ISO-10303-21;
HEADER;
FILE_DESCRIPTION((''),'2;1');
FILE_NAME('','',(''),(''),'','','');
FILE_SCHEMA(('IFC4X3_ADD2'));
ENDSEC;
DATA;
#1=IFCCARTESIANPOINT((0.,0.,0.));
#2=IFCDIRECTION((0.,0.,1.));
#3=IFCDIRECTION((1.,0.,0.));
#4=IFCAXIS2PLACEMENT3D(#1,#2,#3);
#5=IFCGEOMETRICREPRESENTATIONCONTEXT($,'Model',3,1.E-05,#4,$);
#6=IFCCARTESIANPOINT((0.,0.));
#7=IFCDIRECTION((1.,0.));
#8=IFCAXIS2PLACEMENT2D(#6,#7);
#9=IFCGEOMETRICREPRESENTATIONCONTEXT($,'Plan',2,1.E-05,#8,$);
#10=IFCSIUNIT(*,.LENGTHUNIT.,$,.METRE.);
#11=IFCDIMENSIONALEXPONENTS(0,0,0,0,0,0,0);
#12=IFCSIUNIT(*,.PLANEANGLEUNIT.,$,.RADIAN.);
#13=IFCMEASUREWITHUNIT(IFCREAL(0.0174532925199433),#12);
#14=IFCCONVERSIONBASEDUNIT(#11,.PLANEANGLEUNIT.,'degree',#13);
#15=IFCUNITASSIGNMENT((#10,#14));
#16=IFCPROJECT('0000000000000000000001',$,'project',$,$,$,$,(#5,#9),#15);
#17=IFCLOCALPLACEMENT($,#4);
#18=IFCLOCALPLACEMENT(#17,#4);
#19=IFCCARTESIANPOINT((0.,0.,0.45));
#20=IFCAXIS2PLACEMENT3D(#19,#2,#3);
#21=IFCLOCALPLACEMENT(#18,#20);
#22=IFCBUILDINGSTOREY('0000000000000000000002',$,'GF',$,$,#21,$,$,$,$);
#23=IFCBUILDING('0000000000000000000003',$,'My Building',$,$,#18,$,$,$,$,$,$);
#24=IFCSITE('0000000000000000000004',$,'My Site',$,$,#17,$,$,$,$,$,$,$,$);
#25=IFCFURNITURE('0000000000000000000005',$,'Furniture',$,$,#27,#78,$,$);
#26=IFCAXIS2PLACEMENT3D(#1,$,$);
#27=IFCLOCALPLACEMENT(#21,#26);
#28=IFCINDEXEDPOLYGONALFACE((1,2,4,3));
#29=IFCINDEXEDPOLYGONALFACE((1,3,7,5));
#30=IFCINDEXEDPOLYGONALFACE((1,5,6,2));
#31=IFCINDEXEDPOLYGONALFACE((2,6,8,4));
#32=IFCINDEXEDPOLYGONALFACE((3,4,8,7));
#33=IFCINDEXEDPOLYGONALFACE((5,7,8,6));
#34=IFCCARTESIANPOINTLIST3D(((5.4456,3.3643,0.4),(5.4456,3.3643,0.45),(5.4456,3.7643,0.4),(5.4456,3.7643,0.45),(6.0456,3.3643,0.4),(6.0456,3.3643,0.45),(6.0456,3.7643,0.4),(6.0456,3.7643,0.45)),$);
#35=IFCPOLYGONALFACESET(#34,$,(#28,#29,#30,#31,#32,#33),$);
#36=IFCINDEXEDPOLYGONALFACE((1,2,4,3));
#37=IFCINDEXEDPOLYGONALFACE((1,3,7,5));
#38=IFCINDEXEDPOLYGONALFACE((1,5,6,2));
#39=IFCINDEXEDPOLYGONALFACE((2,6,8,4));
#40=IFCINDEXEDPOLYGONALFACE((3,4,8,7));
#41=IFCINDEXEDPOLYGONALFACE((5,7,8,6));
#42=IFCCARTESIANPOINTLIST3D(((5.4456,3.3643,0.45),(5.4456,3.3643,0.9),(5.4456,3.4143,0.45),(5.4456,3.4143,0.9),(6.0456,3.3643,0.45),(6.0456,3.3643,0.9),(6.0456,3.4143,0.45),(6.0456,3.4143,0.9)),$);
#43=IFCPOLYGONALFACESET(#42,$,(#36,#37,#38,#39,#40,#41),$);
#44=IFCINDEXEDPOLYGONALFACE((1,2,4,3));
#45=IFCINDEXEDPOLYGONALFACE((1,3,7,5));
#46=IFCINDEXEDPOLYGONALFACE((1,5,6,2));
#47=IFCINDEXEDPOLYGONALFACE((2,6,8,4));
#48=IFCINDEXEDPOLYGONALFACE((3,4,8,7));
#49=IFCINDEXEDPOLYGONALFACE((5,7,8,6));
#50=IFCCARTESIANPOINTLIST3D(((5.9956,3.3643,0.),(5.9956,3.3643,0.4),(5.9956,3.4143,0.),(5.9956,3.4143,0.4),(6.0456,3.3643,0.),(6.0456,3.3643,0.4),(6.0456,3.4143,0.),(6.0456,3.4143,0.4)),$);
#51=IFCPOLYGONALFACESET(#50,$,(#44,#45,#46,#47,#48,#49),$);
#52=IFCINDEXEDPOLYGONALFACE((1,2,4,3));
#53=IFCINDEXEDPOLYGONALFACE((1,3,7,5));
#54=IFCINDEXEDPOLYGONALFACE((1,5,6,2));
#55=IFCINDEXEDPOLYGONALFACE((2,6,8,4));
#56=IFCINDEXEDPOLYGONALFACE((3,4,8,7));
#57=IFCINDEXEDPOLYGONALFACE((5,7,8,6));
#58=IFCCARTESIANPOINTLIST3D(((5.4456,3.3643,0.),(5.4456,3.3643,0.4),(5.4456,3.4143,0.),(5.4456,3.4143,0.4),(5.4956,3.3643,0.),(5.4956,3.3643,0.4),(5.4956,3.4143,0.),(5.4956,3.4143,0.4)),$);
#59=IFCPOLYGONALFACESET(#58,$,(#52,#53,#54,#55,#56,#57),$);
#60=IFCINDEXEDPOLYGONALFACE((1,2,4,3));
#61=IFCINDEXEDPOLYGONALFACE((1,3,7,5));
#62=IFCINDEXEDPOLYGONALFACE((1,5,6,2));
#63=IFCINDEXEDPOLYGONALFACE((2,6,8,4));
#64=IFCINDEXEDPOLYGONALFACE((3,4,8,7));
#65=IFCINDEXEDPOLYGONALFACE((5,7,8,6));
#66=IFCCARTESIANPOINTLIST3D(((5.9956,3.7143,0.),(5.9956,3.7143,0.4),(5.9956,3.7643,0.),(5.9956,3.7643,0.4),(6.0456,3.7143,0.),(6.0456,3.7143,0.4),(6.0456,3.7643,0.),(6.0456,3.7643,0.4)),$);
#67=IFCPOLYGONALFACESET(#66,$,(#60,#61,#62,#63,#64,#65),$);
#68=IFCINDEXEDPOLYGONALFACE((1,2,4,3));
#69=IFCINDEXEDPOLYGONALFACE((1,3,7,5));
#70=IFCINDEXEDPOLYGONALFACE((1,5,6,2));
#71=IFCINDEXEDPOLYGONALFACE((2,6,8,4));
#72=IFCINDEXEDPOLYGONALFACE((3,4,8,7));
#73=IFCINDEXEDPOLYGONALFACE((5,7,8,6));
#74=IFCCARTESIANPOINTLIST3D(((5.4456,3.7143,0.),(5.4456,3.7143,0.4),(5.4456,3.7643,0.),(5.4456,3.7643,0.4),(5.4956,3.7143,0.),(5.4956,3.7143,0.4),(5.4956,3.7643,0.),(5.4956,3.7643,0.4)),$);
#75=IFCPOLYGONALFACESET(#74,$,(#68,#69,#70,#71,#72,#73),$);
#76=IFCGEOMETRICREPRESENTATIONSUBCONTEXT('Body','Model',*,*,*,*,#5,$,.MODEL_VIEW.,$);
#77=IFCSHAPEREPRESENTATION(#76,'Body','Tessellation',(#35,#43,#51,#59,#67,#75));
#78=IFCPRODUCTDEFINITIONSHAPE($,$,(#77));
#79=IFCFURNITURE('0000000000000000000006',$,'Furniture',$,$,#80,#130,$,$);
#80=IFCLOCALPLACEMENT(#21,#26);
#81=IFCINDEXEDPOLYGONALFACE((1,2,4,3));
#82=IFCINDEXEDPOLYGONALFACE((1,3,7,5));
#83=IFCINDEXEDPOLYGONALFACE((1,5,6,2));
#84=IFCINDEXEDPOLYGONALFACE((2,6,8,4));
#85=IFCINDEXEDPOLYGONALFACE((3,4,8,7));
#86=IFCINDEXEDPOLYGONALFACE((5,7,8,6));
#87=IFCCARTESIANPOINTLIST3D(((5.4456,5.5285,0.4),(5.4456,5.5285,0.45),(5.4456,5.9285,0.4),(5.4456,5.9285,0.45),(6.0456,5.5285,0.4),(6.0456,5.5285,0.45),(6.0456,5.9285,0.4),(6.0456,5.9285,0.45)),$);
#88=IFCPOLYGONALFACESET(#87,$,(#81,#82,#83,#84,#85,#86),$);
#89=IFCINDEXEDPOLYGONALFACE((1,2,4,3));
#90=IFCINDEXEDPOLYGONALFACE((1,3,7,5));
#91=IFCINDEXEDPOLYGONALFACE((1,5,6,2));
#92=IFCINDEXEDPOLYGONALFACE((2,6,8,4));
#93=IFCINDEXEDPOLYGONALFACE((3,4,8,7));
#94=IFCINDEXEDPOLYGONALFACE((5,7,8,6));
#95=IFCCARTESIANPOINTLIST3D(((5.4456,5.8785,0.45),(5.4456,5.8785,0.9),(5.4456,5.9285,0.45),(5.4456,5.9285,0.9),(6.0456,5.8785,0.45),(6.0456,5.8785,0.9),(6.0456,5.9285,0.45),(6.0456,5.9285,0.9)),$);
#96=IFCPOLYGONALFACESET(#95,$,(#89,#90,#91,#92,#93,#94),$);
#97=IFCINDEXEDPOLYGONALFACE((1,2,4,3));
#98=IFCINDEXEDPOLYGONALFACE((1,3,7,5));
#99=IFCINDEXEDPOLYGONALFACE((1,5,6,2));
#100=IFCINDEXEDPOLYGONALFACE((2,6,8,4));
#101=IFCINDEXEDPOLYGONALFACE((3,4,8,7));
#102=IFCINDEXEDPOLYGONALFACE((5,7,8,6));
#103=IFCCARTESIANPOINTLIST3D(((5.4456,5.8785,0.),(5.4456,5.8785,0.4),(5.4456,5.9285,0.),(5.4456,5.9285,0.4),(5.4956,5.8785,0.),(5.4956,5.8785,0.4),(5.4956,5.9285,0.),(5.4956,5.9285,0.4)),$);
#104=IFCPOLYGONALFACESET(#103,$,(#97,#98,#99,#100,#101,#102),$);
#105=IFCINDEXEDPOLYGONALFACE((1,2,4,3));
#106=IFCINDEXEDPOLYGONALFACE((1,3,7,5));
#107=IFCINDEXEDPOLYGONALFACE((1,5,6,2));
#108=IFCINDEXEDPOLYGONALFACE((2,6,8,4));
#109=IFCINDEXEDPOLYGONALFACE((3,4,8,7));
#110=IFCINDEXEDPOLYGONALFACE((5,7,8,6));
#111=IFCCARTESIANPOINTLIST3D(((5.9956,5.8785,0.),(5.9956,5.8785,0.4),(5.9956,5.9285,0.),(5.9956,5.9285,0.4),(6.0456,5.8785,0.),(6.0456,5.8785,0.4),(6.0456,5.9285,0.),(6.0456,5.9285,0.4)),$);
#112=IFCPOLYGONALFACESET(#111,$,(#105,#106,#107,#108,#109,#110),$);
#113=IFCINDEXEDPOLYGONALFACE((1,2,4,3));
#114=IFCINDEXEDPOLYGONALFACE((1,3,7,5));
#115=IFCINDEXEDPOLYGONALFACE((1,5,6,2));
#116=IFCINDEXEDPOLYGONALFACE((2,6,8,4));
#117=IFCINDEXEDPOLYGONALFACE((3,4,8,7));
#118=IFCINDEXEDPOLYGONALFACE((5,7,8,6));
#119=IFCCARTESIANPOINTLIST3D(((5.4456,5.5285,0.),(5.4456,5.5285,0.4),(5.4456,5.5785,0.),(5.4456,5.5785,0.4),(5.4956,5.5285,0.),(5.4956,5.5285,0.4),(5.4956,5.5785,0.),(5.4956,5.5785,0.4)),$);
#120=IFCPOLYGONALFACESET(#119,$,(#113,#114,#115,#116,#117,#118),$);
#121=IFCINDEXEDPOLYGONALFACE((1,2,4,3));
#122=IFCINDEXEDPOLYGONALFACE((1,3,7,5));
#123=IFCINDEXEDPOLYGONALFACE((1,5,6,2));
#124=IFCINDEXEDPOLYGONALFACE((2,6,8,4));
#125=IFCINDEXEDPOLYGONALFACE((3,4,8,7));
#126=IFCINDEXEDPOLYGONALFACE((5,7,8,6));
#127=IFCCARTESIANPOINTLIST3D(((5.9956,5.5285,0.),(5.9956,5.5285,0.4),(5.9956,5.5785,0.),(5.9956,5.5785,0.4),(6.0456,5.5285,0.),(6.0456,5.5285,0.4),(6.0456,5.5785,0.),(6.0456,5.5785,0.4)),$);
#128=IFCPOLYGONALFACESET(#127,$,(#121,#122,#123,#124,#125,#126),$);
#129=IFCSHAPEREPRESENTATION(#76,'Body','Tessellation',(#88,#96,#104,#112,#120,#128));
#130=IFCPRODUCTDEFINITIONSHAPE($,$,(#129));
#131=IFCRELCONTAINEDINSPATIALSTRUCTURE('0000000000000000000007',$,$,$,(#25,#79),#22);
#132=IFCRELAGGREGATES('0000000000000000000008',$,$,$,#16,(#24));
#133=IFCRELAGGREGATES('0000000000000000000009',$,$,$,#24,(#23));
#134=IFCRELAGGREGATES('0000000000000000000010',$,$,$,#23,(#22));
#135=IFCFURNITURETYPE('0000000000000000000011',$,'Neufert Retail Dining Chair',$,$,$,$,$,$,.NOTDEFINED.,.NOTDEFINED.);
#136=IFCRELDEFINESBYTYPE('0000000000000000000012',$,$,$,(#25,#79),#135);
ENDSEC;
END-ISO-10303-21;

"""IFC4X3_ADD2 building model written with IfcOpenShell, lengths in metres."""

from ifc_helpers import new_model, entity, si_unit, converted_unit, frame, origin_with_axes, origin_2d_with_axis, place, context, subcontext, project, spatial, line, indexed_curve, outline, extrude, shape, source, transform, mapped, type_object, type_shapes, element, save


model = new_model("IFC4X3_ADD2")

# Units and contexts
model_context = context("Model", 3, precision=1e-05, world=origin_with_axes())
plan_context = context("Plan", 2, precision=1e-05, world=origin_2d_with_axis())
body_context_1 = subcontext(model_context, "Body", "Model", "MODEL_VIEW")
body_context_2 = subcontext(plan_context, "Body", "Plan", "PLAN_VIEW")
ifc_project = project(units=[si_unit("LENGTHUNIT", "METRE"), converted_unit("PLANEANGLEUNIT", "degree", entity("IfcReal", 0.0174532925199433), si_unit("PLANEANGLEUNIT", "RADIAN"), dimensions=[0, 0, 0, 0, 0, 0, 0])], contexts=[model_context, plan_context])

# Site, building, storey
site_placement = place(None, origin_with_axes())
site = spatial("IfcSite", under=ifc_project, at=site_placement, Name="My Site")
building_placement = place(site_placement, origin_with_axes())
building = spatial("IfcBuilding", under=site, at=building_placement, Name="My Building")
storey_placement = place(building_placement, frame((0.0, 0.0, 0.45), z_axis=(0.0, 0.0, 1.0), x_axis=(1.0, 0.0, 0.0)))
storey = spatial("IfcBuildingStorey", under=building, at=storey_placement, Name="GF")

# Furniture
furniture_type = type_object("IfcFurnitureType", Name="Neufert Retail Dining Chair", AssemblyPlace="NOTDEFINED", PredefinedType="NOTDEFINED")
shared_shape_1 = source(origin_with_axes(), body_context_1, "Body", "SweptSolid", [
    extrude(outline(indexed_curve([(-0.3, 0.0), (0.3, 0.0), (0.3, -0.4), (-0.3, -0.4)], segments=[line(1, 2, 3, 4, 1)])), frame((0.0, 0.0, 0.45), z_axis=(0.0, 0.0, 1.0), x_axis=(1.0, 0.0, 0.0)), (0.0, 0.0, -1.0), 0.05),
    extrude(outline(indexed_curve([(-0.3, 0.0), (0.3, 0.0), (0.3, -0.05), (-0.3, -0.05)], segments=[line(1, 2, 3, 4, 1)])), frame((0.0, 0.0, 0.9), z_axis=(0.0, 0.0, 1.0), x_axis=(1.0, 0.0, 0.0)), (0.0, 0.0, -1.0), 0.45),
    extrude(outline(indexed_curve([(-0.3, 0.0), (-0.25, 0.0), (-0.25, -0.05), (-0.3, -0.05)], segments=[line(1, 2, 3, 4, 1)])), origin_with_axes(), (0.0, 0.0, 1.0), 0.4),
    extrude(outline(indexed_curve([(0.3, 0.0), (0.25, 0.0), (0.25, -0.05), (0.3, -0.05)], segments=[line(1, 2, 3, 4, 1)])), origin_with_axes(), (0.0, 0.0, 1.0), 0.4),
    extrude(outline(indexed_curve([(-0.3, -0.4), (-0.25, -0.4), (-0.25, -0.35), (-0.3, -0.35)], segments=[line(1, 2, 3, 4, 1)])), origin_with_axes(), (0.0, 0.0, 1.0), 0.4),
    extrude(outline(indexed_curve([(0.3, -0.4), (0.25, -0.4), (0.25, -0.35), (0.3, -0.35)], segments=[line(1, 2, 3, 4, 1)])), origin_with_axes(), (0.0, 0.0, 1.0), 0.4),
])
shared_shape_2 = source(origin_with_axes(), body_context_2, "Body", "Curve2D", [
    entity("IfcIndexedPolyCurve", entity("IfcCartesianPointList2D", [[-0.3, -0.4], [0.3, -0.4]])),
    entity("IfcIndexedPolyCurve", entity("IfcCartesianPointList2D", [[-0.3, -0.4], [-0.3, -0.3], [-0.2121, -0.0879], [0.0, 0.0], [0.2121, -0.0879], [0.3, -0.3], [0.3, -0.4]]), [entity("IfcLineIndex", [1, 2]), entity("IfcArcIndex", [2, 3, 4]), entity("IfcArcIndex", [4, 5, 6]), entity("IfcLineIndex", [6, 7])]),
    entity("IfcIndexedPolyCurve", entity("IfcCartesianPointList2D", [[-0.26, -0.4], [-0.26, -0.3], [-0.1838, -0.1162], [0.0, -0.04], [0.1838, -0.1162], [0.26, -0.3], [0.26, -0.4]]), [entity("IfcLineIndex", [1, 2]), entity("IfcArcIndex", [2, 3, 4]), entity("IfcArcIndex", [4, 5, 6]), entity("IfcLineIndex", [6, 7])]),
])
type_shapes(furniture_type, [shared_shape_1, shared_shape_2])
for number, where, z_axis, x_axis, name in (
    (1, (5.7456, 3.3643, 0.0), (0.0, 0.0, 1.0), (-1.0, 0.000001, 0.0), "Furniture"),
    (2, (5.7456, 5.9285, 0.0), (0.0, 0.0, 1.0), (1.0, -0.000001, 0.0), "Furniture"),
):
    element("IfcFurniture", number, at=place(storey_placement, frame(where, z_axis=z_axis, x_axis=x_axis)), inside=storey, type_object=furniture_type, Name=name, shapes=[
        shape(body_context_1, "Body", "MappedRepresentation", [mapped(shared_shape_1, transform((0.0, 0.0, 0.0), x_axis=(1.0, 0.0, 0.0), y_axis=(0.0, 1.0, 0.0), z_axis=(0.0, 0.0, 1.0), scale=1.0))]),
        shape(body_context_2, "Body", "MappedRepresentation", [mapped(shared_shape_2, transform((0.0, 0.0, 0.0), x_axis=(1.0, 0.0, 0.0), y_axis=(0.0, 1.0, 0.0), z_axis=(0.0, 0.0, 1.0), scale=1.0))]),
    ])

save(model, "model.ifc")
